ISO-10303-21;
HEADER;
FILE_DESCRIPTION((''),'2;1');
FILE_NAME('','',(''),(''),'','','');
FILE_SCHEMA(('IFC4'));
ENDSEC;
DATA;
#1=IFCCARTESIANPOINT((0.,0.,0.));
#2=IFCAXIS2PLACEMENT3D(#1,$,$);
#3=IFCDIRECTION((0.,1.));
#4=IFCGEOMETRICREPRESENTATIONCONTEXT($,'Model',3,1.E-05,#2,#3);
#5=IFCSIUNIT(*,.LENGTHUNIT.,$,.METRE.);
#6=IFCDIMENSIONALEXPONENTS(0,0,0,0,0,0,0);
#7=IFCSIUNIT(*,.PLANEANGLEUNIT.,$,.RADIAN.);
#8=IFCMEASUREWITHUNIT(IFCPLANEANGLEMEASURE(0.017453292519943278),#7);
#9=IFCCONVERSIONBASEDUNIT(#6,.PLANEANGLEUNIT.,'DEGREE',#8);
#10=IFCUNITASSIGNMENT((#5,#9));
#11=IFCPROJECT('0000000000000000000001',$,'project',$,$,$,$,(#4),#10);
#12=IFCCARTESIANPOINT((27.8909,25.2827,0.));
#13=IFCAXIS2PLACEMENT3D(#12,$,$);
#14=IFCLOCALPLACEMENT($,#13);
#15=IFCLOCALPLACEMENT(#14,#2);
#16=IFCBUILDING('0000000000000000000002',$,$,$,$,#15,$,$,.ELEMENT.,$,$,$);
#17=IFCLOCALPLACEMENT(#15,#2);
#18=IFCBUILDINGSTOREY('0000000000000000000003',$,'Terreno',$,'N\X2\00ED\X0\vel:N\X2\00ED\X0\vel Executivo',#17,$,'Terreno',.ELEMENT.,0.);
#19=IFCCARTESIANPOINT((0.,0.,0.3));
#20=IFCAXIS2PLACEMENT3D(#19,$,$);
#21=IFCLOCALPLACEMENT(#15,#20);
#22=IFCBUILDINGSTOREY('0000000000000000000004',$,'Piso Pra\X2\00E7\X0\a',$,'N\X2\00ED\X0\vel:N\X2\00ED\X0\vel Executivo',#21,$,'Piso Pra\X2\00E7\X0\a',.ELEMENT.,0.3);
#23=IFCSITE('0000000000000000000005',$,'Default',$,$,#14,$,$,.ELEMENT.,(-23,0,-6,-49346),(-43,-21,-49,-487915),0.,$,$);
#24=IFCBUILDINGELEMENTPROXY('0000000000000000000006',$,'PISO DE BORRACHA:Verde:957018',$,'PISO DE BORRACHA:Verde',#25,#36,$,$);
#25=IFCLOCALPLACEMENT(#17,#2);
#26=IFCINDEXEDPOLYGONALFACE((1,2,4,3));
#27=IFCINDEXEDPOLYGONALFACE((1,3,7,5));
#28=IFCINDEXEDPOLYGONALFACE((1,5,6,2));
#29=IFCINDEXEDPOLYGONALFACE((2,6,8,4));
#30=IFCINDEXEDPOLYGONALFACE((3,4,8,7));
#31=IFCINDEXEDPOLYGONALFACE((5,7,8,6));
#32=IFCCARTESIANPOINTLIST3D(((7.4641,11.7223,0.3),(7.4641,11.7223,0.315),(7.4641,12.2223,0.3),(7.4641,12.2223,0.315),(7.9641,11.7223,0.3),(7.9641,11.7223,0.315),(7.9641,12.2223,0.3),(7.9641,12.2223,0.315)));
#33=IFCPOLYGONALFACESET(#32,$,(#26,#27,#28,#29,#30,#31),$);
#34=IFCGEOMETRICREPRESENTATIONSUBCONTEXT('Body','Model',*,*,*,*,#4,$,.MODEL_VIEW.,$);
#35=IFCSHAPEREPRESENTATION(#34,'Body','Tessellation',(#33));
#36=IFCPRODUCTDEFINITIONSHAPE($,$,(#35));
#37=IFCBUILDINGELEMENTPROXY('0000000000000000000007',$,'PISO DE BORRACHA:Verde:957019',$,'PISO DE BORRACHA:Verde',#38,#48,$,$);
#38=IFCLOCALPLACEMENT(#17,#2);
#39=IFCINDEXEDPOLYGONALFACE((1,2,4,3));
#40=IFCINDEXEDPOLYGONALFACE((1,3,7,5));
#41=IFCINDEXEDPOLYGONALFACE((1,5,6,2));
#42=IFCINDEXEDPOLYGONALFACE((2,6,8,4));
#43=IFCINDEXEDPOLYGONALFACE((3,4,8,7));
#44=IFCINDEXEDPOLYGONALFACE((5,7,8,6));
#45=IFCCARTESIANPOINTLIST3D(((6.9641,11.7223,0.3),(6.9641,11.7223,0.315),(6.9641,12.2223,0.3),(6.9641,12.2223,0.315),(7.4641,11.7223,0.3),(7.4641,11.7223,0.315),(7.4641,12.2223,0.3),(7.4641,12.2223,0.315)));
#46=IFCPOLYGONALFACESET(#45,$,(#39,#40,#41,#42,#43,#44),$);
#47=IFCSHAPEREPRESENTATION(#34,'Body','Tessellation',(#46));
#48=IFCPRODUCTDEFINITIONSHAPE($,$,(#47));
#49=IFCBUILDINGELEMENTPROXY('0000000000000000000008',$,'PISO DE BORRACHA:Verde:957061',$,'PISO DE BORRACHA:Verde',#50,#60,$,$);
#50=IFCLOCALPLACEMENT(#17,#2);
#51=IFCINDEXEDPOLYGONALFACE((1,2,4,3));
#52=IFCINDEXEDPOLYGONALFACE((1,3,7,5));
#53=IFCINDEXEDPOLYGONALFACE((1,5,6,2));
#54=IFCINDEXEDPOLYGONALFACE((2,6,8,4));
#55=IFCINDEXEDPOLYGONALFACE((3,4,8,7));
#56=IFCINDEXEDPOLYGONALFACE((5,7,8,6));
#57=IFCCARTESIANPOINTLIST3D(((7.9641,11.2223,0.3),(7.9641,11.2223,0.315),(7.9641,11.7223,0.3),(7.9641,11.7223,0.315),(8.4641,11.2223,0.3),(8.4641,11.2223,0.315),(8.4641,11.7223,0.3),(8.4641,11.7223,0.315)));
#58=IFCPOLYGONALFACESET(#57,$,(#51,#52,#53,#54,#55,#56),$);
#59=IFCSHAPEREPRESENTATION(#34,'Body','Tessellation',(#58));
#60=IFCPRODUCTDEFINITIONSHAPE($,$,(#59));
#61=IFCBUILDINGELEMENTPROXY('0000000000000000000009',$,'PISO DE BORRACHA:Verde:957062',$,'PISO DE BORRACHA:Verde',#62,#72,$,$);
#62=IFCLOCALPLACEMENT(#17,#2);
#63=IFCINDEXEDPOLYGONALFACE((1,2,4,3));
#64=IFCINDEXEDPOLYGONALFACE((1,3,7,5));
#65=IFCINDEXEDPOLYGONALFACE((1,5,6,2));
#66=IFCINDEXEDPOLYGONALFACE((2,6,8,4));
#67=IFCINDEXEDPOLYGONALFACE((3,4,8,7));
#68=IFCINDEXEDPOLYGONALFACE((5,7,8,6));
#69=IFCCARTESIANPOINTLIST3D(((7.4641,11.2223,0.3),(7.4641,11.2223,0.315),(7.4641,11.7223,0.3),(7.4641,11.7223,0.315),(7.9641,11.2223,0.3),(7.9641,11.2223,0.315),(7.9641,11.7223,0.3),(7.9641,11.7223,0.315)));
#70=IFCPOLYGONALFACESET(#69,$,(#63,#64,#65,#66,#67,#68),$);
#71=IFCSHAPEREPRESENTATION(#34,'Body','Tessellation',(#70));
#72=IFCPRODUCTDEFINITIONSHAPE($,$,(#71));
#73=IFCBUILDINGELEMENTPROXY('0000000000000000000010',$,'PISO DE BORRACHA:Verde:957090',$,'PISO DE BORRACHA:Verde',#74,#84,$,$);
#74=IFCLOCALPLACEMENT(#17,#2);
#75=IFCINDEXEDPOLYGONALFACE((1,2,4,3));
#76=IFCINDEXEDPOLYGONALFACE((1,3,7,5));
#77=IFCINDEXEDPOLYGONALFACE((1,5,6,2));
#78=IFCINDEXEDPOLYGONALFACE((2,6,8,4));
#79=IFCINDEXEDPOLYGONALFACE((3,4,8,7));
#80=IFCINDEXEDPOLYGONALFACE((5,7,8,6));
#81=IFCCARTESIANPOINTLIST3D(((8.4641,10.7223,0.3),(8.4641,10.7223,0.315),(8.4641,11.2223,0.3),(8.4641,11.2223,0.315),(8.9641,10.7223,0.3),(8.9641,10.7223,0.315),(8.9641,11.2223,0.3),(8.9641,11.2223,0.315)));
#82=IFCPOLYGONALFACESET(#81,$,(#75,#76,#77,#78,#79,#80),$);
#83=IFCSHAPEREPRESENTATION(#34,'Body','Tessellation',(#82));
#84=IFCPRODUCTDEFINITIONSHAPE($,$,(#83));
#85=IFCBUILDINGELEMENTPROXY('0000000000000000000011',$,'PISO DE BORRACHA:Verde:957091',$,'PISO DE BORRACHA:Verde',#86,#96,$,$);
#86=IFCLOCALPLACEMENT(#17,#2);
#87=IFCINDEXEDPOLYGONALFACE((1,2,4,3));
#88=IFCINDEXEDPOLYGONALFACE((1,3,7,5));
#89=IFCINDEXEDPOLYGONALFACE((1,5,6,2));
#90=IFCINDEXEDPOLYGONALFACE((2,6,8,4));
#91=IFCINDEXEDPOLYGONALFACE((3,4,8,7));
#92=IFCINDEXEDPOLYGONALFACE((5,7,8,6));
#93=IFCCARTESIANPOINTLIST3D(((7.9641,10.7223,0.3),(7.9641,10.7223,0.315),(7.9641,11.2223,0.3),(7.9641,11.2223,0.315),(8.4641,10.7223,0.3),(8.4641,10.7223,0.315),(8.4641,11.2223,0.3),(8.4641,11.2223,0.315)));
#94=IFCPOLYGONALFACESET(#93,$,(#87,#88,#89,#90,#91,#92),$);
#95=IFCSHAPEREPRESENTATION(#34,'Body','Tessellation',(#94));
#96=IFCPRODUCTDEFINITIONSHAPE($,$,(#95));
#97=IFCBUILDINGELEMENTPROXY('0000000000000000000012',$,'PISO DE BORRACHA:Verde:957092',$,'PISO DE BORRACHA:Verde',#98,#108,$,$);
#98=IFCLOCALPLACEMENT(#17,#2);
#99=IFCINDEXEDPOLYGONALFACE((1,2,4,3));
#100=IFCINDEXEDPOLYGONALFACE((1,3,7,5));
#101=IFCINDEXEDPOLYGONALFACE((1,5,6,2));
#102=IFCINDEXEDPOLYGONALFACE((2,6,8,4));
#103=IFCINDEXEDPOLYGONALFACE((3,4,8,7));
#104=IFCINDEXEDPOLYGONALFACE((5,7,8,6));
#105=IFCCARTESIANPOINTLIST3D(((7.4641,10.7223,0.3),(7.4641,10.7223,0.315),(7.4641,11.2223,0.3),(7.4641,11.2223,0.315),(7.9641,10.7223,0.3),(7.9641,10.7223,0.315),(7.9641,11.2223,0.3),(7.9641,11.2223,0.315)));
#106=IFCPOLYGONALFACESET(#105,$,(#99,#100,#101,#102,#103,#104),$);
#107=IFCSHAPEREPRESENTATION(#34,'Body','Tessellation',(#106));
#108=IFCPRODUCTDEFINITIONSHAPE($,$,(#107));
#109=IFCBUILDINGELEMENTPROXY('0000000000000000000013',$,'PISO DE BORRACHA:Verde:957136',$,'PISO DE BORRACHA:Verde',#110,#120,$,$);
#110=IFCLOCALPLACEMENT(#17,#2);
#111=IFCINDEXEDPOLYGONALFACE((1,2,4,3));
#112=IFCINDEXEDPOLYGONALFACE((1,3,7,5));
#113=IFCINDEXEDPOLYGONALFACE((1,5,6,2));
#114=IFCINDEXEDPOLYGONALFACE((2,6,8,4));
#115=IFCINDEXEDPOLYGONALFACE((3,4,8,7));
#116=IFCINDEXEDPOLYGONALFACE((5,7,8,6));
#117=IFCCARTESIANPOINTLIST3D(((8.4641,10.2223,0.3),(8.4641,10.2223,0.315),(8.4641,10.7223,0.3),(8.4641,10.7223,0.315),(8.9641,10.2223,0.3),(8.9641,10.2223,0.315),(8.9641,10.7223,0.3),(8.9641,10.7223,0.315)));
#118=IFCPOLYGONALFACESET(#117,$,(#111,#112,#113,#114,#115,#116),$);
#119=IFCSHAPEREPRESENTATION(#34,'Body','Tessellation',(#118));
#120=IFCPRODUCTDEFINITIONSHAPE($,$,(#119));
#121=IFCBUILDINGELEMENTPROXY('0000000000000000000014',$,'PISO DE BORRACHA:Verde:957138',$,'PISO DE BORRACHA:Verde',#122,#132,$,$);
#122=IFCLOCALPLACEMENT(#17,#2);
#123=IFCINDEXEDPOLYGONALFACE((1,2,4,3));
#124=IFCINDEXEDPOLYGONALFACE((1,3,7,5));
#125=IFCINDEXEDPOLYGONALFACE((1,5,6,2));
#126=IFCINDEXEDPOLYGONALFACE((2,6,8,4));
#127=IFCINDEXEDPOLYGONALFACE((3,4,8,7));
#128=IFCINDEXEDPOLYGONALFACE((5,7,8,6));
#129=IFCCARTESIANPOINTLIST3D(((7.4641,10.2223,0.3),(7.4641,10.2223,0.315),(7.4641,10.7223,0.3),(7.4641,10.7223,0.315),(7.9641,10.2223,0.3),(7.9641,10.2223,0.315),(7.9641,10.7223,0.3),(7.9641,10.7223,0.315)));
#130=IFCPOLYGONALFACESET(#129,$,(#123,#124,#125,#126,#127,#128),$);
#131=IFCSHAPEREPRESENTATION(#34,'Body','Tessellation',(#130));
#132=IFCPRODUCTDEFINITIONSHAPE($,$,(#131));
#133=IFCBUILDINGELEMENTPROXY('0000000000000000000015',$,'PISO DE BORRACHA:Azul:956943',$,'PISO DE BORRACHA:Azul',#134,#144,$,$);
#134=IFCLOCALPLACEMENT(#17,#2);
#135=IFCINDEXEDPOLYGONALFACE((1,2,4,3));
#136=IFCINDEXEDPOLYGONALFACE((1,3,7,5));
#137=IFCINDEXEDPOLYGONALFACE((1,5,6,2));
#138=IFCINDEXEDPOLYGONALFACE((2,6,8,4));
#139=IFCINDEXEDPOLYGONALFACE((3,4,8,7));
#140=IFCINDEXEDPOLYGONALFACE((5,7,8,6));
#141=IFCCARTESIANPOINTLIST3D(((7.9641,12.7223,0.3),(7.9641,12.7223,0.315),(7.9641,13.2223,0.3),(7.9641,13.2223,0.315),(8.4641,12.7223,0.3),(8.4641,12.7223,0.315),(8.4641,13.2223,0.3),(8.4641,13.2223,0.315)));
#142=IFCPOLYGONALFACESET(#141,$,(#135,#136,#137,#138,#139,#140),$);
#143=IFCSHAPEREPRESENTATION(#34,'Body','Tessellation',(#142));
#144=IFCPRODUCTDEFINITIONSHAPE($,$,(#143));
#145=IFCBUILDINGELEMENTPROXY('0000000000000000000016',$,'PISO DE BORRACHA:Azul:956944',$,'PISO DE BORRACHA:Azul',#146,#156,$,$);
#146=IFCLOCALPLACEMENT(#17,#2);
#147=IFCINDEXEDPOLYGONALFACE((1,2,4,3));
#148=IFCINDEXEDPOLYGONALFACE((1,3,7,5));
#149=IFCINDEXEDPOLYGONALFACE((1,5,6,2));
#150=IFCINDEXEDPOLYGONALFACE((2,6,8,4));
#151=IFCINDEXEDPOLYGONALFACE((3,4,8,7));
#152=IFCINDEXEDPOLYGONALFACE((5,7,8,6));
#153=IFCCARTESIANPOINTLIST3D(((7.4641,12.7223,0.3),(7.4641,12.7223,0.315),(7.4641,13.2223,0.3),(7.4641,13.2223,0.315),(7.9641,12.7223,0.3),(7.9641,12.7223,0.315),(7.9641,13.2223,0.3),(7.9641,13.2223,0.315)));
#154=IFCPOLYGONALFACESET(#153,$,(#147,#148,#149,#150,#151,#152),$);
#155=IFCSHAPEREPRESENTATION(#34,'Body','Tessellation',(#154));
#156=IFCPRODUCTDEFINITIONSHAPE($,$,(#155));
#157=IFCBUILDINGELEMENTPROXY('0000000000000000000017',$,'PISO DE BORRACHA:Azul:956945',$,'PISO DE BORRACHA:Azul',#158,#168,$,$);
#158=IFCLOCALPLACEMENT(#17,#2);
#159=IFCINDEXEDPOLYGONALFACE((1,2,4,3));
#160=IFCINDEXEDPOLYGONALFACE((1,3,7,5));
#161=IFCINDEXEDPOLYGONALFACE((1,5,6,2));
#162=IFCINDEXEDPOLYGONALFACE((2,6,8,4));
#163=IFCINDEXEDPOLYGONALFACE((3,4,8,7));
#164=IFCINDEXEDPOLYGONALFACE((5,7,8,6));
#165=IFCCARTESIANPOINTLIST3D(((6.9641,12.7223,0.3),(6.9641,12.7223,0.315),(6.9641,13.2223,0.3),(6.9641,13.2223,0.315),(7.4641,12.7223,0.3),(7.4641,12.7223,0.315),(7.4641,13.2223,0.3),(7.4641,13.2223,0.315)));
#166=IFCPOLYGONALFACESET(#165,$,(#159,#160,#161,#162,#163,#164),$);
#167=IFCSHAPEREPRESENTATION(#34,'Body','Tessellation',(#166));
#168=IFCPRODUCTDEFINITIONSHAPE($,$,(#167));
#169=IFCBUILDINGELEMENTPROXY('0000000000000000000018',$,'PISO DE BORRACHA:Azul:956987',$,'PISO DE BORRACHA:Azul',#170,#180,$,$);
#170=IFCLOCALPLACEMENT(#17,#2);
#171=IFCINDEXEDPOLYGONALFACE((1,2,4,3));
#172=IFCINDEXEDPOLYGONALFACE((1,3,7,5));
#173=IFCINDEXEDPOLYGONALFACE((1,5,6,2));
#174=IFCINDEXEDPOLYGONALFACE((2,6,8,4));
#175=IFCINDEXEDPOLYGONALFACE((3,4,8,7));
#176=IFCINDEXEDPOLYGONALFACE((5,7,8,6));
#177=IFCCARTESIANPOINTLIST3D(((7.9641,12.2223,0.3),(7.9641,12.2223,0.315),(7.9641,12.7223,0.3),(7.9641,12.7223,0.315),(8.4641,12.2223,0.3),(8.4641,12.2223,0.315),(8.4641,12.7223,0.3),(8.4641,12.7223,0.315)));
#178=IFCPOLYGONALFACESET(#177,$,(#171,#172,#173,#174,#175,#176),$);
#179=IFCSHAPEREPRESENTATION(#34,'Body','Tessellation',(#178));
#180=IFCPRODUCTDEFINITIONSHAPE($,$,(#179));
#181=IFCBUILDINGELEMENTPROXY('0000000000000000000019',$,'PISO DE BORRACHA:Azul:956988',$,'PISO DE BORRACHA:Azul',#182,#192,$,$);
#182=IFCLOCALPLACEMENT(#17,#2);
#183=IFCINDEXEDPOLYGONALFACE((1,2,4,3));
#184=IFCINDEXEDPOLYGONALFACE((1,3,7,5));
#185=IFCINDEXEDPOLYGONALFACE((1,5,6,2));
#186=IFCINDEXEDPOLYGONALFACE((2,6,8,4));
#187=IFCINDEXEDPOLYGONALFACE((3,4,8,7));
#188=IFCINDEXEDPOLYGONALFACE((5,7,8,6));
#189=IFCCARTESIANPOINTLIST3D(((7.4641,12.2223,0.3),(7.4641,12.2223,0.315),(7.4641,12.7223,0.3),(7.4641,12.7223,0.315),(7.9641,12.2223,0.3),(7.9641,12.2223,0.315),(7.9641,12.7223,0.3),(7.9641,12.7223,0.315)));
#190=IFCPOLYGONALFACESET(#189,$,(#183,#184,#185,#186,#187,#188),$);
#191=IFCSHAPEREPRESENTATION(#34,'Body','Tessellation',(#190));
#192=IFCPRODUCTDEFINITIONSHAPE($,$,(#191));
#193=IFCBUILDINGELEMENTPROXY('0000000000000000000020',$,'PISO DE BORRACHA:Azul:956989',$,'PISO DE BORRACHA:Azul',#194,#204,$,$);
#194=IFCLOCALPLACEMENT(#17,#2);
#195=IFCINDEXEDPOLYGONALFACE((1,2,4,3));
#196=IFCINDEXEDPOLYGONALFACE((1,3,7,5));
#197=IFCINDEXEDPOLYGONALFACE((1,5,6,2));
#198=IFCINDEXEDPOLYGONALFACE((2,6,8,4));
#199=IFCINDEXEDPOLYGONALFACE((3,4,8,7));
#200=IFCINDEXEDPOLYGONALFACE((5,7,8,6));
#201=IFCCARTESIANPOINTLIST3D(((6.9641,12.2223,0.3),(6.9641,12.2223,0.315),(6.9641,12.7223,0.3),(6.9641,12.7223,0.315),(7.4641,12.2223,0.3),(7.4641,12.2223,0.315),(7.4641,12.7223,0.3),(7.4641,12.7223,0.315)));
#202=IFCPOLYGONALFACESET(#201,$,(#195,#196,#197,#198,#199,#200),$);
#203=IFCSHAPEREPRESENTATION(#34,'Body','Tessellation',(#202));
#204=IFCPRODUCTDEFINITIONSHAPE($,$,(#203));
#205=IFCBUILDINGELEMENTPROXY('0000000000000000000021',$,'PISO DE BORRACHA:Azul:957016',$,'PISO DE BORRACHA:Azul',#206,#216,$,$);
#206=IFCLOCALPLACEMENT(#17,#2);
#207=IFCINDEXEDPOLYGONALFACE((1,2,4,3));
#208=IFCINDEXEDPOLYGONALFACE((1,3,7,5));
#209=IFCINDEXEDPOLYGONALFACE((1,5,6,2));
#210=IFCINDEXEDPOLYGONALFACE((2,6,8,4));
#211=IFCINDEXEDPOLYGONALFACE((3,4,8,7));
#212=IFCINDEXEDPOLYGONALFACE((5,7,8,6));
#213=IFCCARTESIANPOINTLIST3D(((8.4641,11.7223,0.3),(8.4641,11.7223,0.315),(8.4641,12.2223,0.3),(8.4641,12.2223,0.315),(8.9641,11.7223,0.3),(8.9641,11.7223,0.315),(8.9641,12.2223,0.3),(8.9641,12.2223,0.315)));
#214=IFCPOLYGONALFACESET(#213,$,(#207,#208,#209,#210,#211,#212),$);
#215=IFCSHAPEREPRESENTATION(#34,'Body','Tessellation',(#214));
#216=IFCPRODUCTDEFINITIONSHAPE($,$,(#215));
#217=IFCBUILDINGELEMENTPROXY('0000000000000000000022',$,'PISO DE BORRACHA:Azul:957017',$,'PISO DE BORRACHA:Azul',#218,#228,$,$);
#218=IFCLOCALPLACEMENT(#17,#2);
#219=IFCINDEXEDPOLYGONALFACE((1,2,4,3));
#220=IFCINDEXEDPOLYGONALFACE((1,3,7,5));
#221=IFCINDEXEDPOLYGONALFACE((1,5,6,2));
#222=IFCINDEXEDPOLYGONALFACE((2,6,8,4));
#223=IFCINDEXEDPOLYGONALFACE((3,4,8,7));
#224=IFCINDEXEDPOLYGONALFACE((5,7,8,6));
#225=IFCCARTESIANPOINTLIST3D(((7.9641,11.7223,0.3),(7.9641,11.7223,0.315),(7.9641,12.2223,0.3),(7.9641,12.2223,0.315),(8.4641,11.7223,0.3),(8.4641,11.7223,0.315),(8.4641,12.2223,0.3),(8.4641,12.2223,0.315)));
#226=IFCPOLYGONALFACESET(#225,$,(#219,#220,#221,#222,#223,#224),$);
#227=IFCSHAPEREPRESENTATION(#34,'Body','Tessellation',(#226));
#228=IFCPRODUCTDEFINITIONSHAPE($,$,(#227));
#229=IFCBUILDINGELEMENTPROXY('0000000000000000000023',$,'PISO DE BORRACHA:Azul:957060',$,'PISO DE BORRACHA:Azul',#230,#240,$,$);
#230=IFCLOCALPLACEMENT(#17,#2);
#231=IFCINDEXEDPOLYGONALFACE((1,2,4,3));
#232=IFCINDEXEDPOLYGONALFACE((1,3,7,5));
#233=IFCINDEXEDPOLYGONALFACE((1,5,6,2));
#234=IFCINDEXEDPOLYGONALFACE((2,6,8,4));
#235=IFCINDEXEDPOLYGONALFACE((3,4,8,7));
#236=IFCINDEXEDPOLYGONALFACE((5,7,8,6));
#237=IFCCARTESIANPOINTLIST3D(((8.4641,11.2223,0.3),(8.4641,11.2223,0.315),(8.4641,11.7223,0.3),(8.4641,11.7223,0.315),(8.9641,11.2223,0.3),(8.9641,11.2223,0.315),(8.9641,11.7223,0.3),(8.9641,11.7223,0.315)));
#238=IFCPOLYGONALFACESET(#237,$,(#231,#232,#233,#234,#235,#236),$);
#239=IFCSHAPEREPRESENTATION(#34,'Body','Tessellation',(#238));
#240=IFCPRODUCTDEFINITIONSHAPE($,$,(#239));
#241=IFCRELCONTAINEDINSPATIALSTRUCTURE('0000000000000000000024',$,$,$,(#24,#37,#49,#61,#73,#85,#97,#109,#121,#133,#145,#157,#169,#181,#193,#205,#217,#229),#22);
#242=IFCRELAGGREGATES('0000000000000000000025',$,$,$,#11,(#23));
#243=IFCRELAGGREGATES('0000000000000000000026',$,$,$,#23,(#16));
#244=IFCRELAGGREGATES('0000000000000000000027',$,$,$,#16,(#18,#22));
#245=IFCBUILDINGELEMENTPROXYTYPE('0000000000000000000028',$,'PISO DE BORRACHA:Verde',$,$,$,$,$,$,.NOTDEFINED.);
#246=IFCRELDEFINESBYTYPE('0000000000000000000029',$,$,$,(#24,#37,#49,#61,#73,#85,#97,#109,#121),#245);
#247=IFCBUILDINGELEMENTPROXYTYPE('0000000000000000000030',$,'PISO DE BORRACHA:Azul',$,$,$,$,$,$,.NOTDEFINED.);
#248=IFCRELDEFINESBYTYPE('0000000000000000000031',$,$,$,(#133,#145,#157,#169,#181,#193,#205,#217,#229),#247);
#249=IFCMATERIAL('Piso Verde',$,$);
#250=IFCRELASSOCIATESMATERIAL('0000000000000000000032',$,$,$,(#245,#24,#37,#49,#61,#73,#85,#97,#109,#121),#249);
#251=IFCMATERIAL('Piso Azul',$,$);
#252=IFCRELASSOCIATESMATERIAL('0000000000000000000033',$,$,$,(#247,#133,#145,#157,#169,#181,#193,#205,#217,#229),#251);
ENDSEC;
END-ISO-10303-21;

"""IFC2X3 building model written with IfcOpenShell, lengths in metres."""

from ifc_helpers import new_model, entity, si_unit, converted_unit, direction, frame, origin, origin_2d_with_axis, place, context, subcontext, project, spatial, rectangle, extrude, source, transform, mapped, material, type_object, type_shapes, element, save


model = new_model("IFC2X3")

# Units and contexts
model_context = context("Model", 3, precision=1e-05, world=origin(), true_north=direction((0.0, 1.0)))
body_context = subcontext(model_context, "Body", "Model", "MODEL_VIEW")
ifc_project = project(units=[si_unit("LENGTHUNIT", "METRE"), converted_unit("PLANEANGLEUNIT", "DEGREE", entity("IfcPlaneAngleMeasure", 0.017453292519943278), si_unit("PLANEANGLEUNIT", "RADIAN"), dimensions=[0, 0, 0, 0, 0, 0, 0])], contexts=[model_context])

# Site, building, storey
site_placement = place(None, frame((27.8909, 25.2827, 0.0)))
site = spatial("IfcSite", under=ifc_project, at=site_placement, Name="Default", CompositionType="ELEMENT", RefLatitude=(-23, 0, -6, -49346), RefLongitude=(-43, -21, -49, -487915), RefElevation=0.0)
building_placement = place(site_placement, origin())
building = spatial("IfcBuilding", under=site, at=building_placement, CompositionType="ELEMENT")
storey_1_placement = place(building_placement, origin())
storey_1 = spatial("IfcBuildingStorey", under=building, at=storey_1_placement, Name="Terreno", ObjectType="Nível:Nível Executivo", LongName="Terreno", CompositionType="ELEMENT", Elevation=0.0)

# Shared definitions
storey_2_placement = place(building_placement, frame((0.0, 0.0, 0.3)))
storey_2 = spatial("IfcBuildingStorey", under=building, at=storey_2_placement, Name="Piso Praça", ObjectType="Nível:Nível Executivo", LongName="Piso Praça", CompositionType="ELEMENT", Elevation=0.3)

# Building element proxies
ifc_material_1 = material(Name="Piso Verde")
building_element_proxy_type_1 = type_object("IfcBuildingElementProxyType", Name="PISO DE BORRACHA:Verde", PredefinedType="NOTDEFINED", material=ifc_material_1)
shared_shape_1 = source(origin(), body_context, "Body", "SweptSolid", [
    extrude(rectangle(XDim=0.5, YDim=0.5, at=origin_2d_with_axis()), frame((0.25, 0.25, 0.0), z_axis=(0.0, 0.0, 1.0), x_axis=(-1.0, 0.0, 0.0)), (0.0, 0.0, 1.0), 0.015),
])
type_shapes(building_element_proxy_type_1, [shared_shape_1])
for number, where, name in (
    (1, (7.4641, 11.7223, 0.0), "PISO DE BORRACHA:Verde:957018"),
    (2, (6.9641, 11.7223, 0.0), "PISO DE BORRACHA:Verde:957019"),
    (3, (7.9641, 11.2223, 0.0), "PISO DE BORRACHA:Verde:957061"),
    (4, (7.4641, 11.2223, 0.0), "PISO DE BORRACHA:Verde:957062"),
    (5, (8.4641, 10.7223, 0.0), "PISO DE BORRACHA:Verde:957090"),
    (6, (7.9641, 10.7223, 0.0), "PISO DE BORRACHA:Verde:957091"),
    (7, (7.4641, 10.7223, 0.0), "PISO DE BORRACHA:Verde:957092"),
    (8, (8.4641, 10.2223, 0.0), "PISO DE BORRACHA:Verde:957136"),
    (9, (7.4641, 10.2223, 0.0), "PISO DE BORRACHA:Verde:957138"),
):
    element("IfcBuildingElementProxy", number, at=place(storey_2_placement, frame(where)), inside=storey_2, type_object=building_element_proxy_type_1, material=ifc_material_1, Name=name, ObjectType="PISO DE BORRACHA:Verde", context=body_context, shape_type="MappedRepresentation", body=[
        mapped(shared_shape_1, transform((0.0, 0.0, 0.0), scale=1.0)),
    ])
ifc_material_2 = material(Name="Piso Azul")
building_element_proxy_type_2 = type_object("IfcBuildingElementProxyType", Name="PISO DE BORRACHA:Azul", PredefinedType="NOTDEFINED", material=ifc_material_2)
shared_shape_2 = source(origin(), body_context, "Body", "SweptSolid", [
    extrude(rectangle(XDim=0.5, YDim=0.5, at=origin_2d_with_axis()), frame((0.25, 0.25, 0.0), z_axis=(0.0, 0.0, 1.0), x_axis=(-1.0, 0.0, 0.0)), (0.0, 0.0, 1.0), 0.015),
])
type_shapes(building_element_proxy_type_2, [shared_shape_2])
for number, where, name in (
    (10, (7.9641, 12.7223, 0.0), "PISO DE BORRACHA:Azul:956943"),
    (11, (7.4641, 12.7223, 0.0), "PISO DE BORRACHA:Azul:956944"),
    (12, (6.9641, 12.7223, 0.0), "PISO DE BORRACHA:Azul:956945"),
    (13, (7.9641, 12.2223, 0.0), "PISO DE BORRACHA:Azul:956987"),
    (14, (7.4641, 12.2223, 0.0), "PISO DE BORRACHA:Azul:956988"),
    (15, (6.9641, 12.2223, 0.0), "PISO DE BORRACHA:Azul:956989"),
    (16, (8.4641, 11.7223, 0.0), "PISO DE BORRACHA:Azul:957016"),
    (17, (7.9641, 11.7223, 0.0), "PISO DE BORRACHA:Azul:957017"),
    (18, (8.4641, 11.2223, 0.0), "PISO DE BORRACHA:Azul:957060"),
):
    element("IfcBuildingElementProxy", number, at=place(storey_2_placement, frame(where)), inside=storey_2, type_object=building_element_proxy_type_2, material=ifc_material_2, Name=name, ObjectType="PISO DE BORRACHA:Azul", context=body_context, shape_type="MappedRepresentation", body=[
        mapped(shared_shape_2, transform((0.0, 0.0, 0.0), scale=1.0)),
    ])

save(model, "model.ifc")
